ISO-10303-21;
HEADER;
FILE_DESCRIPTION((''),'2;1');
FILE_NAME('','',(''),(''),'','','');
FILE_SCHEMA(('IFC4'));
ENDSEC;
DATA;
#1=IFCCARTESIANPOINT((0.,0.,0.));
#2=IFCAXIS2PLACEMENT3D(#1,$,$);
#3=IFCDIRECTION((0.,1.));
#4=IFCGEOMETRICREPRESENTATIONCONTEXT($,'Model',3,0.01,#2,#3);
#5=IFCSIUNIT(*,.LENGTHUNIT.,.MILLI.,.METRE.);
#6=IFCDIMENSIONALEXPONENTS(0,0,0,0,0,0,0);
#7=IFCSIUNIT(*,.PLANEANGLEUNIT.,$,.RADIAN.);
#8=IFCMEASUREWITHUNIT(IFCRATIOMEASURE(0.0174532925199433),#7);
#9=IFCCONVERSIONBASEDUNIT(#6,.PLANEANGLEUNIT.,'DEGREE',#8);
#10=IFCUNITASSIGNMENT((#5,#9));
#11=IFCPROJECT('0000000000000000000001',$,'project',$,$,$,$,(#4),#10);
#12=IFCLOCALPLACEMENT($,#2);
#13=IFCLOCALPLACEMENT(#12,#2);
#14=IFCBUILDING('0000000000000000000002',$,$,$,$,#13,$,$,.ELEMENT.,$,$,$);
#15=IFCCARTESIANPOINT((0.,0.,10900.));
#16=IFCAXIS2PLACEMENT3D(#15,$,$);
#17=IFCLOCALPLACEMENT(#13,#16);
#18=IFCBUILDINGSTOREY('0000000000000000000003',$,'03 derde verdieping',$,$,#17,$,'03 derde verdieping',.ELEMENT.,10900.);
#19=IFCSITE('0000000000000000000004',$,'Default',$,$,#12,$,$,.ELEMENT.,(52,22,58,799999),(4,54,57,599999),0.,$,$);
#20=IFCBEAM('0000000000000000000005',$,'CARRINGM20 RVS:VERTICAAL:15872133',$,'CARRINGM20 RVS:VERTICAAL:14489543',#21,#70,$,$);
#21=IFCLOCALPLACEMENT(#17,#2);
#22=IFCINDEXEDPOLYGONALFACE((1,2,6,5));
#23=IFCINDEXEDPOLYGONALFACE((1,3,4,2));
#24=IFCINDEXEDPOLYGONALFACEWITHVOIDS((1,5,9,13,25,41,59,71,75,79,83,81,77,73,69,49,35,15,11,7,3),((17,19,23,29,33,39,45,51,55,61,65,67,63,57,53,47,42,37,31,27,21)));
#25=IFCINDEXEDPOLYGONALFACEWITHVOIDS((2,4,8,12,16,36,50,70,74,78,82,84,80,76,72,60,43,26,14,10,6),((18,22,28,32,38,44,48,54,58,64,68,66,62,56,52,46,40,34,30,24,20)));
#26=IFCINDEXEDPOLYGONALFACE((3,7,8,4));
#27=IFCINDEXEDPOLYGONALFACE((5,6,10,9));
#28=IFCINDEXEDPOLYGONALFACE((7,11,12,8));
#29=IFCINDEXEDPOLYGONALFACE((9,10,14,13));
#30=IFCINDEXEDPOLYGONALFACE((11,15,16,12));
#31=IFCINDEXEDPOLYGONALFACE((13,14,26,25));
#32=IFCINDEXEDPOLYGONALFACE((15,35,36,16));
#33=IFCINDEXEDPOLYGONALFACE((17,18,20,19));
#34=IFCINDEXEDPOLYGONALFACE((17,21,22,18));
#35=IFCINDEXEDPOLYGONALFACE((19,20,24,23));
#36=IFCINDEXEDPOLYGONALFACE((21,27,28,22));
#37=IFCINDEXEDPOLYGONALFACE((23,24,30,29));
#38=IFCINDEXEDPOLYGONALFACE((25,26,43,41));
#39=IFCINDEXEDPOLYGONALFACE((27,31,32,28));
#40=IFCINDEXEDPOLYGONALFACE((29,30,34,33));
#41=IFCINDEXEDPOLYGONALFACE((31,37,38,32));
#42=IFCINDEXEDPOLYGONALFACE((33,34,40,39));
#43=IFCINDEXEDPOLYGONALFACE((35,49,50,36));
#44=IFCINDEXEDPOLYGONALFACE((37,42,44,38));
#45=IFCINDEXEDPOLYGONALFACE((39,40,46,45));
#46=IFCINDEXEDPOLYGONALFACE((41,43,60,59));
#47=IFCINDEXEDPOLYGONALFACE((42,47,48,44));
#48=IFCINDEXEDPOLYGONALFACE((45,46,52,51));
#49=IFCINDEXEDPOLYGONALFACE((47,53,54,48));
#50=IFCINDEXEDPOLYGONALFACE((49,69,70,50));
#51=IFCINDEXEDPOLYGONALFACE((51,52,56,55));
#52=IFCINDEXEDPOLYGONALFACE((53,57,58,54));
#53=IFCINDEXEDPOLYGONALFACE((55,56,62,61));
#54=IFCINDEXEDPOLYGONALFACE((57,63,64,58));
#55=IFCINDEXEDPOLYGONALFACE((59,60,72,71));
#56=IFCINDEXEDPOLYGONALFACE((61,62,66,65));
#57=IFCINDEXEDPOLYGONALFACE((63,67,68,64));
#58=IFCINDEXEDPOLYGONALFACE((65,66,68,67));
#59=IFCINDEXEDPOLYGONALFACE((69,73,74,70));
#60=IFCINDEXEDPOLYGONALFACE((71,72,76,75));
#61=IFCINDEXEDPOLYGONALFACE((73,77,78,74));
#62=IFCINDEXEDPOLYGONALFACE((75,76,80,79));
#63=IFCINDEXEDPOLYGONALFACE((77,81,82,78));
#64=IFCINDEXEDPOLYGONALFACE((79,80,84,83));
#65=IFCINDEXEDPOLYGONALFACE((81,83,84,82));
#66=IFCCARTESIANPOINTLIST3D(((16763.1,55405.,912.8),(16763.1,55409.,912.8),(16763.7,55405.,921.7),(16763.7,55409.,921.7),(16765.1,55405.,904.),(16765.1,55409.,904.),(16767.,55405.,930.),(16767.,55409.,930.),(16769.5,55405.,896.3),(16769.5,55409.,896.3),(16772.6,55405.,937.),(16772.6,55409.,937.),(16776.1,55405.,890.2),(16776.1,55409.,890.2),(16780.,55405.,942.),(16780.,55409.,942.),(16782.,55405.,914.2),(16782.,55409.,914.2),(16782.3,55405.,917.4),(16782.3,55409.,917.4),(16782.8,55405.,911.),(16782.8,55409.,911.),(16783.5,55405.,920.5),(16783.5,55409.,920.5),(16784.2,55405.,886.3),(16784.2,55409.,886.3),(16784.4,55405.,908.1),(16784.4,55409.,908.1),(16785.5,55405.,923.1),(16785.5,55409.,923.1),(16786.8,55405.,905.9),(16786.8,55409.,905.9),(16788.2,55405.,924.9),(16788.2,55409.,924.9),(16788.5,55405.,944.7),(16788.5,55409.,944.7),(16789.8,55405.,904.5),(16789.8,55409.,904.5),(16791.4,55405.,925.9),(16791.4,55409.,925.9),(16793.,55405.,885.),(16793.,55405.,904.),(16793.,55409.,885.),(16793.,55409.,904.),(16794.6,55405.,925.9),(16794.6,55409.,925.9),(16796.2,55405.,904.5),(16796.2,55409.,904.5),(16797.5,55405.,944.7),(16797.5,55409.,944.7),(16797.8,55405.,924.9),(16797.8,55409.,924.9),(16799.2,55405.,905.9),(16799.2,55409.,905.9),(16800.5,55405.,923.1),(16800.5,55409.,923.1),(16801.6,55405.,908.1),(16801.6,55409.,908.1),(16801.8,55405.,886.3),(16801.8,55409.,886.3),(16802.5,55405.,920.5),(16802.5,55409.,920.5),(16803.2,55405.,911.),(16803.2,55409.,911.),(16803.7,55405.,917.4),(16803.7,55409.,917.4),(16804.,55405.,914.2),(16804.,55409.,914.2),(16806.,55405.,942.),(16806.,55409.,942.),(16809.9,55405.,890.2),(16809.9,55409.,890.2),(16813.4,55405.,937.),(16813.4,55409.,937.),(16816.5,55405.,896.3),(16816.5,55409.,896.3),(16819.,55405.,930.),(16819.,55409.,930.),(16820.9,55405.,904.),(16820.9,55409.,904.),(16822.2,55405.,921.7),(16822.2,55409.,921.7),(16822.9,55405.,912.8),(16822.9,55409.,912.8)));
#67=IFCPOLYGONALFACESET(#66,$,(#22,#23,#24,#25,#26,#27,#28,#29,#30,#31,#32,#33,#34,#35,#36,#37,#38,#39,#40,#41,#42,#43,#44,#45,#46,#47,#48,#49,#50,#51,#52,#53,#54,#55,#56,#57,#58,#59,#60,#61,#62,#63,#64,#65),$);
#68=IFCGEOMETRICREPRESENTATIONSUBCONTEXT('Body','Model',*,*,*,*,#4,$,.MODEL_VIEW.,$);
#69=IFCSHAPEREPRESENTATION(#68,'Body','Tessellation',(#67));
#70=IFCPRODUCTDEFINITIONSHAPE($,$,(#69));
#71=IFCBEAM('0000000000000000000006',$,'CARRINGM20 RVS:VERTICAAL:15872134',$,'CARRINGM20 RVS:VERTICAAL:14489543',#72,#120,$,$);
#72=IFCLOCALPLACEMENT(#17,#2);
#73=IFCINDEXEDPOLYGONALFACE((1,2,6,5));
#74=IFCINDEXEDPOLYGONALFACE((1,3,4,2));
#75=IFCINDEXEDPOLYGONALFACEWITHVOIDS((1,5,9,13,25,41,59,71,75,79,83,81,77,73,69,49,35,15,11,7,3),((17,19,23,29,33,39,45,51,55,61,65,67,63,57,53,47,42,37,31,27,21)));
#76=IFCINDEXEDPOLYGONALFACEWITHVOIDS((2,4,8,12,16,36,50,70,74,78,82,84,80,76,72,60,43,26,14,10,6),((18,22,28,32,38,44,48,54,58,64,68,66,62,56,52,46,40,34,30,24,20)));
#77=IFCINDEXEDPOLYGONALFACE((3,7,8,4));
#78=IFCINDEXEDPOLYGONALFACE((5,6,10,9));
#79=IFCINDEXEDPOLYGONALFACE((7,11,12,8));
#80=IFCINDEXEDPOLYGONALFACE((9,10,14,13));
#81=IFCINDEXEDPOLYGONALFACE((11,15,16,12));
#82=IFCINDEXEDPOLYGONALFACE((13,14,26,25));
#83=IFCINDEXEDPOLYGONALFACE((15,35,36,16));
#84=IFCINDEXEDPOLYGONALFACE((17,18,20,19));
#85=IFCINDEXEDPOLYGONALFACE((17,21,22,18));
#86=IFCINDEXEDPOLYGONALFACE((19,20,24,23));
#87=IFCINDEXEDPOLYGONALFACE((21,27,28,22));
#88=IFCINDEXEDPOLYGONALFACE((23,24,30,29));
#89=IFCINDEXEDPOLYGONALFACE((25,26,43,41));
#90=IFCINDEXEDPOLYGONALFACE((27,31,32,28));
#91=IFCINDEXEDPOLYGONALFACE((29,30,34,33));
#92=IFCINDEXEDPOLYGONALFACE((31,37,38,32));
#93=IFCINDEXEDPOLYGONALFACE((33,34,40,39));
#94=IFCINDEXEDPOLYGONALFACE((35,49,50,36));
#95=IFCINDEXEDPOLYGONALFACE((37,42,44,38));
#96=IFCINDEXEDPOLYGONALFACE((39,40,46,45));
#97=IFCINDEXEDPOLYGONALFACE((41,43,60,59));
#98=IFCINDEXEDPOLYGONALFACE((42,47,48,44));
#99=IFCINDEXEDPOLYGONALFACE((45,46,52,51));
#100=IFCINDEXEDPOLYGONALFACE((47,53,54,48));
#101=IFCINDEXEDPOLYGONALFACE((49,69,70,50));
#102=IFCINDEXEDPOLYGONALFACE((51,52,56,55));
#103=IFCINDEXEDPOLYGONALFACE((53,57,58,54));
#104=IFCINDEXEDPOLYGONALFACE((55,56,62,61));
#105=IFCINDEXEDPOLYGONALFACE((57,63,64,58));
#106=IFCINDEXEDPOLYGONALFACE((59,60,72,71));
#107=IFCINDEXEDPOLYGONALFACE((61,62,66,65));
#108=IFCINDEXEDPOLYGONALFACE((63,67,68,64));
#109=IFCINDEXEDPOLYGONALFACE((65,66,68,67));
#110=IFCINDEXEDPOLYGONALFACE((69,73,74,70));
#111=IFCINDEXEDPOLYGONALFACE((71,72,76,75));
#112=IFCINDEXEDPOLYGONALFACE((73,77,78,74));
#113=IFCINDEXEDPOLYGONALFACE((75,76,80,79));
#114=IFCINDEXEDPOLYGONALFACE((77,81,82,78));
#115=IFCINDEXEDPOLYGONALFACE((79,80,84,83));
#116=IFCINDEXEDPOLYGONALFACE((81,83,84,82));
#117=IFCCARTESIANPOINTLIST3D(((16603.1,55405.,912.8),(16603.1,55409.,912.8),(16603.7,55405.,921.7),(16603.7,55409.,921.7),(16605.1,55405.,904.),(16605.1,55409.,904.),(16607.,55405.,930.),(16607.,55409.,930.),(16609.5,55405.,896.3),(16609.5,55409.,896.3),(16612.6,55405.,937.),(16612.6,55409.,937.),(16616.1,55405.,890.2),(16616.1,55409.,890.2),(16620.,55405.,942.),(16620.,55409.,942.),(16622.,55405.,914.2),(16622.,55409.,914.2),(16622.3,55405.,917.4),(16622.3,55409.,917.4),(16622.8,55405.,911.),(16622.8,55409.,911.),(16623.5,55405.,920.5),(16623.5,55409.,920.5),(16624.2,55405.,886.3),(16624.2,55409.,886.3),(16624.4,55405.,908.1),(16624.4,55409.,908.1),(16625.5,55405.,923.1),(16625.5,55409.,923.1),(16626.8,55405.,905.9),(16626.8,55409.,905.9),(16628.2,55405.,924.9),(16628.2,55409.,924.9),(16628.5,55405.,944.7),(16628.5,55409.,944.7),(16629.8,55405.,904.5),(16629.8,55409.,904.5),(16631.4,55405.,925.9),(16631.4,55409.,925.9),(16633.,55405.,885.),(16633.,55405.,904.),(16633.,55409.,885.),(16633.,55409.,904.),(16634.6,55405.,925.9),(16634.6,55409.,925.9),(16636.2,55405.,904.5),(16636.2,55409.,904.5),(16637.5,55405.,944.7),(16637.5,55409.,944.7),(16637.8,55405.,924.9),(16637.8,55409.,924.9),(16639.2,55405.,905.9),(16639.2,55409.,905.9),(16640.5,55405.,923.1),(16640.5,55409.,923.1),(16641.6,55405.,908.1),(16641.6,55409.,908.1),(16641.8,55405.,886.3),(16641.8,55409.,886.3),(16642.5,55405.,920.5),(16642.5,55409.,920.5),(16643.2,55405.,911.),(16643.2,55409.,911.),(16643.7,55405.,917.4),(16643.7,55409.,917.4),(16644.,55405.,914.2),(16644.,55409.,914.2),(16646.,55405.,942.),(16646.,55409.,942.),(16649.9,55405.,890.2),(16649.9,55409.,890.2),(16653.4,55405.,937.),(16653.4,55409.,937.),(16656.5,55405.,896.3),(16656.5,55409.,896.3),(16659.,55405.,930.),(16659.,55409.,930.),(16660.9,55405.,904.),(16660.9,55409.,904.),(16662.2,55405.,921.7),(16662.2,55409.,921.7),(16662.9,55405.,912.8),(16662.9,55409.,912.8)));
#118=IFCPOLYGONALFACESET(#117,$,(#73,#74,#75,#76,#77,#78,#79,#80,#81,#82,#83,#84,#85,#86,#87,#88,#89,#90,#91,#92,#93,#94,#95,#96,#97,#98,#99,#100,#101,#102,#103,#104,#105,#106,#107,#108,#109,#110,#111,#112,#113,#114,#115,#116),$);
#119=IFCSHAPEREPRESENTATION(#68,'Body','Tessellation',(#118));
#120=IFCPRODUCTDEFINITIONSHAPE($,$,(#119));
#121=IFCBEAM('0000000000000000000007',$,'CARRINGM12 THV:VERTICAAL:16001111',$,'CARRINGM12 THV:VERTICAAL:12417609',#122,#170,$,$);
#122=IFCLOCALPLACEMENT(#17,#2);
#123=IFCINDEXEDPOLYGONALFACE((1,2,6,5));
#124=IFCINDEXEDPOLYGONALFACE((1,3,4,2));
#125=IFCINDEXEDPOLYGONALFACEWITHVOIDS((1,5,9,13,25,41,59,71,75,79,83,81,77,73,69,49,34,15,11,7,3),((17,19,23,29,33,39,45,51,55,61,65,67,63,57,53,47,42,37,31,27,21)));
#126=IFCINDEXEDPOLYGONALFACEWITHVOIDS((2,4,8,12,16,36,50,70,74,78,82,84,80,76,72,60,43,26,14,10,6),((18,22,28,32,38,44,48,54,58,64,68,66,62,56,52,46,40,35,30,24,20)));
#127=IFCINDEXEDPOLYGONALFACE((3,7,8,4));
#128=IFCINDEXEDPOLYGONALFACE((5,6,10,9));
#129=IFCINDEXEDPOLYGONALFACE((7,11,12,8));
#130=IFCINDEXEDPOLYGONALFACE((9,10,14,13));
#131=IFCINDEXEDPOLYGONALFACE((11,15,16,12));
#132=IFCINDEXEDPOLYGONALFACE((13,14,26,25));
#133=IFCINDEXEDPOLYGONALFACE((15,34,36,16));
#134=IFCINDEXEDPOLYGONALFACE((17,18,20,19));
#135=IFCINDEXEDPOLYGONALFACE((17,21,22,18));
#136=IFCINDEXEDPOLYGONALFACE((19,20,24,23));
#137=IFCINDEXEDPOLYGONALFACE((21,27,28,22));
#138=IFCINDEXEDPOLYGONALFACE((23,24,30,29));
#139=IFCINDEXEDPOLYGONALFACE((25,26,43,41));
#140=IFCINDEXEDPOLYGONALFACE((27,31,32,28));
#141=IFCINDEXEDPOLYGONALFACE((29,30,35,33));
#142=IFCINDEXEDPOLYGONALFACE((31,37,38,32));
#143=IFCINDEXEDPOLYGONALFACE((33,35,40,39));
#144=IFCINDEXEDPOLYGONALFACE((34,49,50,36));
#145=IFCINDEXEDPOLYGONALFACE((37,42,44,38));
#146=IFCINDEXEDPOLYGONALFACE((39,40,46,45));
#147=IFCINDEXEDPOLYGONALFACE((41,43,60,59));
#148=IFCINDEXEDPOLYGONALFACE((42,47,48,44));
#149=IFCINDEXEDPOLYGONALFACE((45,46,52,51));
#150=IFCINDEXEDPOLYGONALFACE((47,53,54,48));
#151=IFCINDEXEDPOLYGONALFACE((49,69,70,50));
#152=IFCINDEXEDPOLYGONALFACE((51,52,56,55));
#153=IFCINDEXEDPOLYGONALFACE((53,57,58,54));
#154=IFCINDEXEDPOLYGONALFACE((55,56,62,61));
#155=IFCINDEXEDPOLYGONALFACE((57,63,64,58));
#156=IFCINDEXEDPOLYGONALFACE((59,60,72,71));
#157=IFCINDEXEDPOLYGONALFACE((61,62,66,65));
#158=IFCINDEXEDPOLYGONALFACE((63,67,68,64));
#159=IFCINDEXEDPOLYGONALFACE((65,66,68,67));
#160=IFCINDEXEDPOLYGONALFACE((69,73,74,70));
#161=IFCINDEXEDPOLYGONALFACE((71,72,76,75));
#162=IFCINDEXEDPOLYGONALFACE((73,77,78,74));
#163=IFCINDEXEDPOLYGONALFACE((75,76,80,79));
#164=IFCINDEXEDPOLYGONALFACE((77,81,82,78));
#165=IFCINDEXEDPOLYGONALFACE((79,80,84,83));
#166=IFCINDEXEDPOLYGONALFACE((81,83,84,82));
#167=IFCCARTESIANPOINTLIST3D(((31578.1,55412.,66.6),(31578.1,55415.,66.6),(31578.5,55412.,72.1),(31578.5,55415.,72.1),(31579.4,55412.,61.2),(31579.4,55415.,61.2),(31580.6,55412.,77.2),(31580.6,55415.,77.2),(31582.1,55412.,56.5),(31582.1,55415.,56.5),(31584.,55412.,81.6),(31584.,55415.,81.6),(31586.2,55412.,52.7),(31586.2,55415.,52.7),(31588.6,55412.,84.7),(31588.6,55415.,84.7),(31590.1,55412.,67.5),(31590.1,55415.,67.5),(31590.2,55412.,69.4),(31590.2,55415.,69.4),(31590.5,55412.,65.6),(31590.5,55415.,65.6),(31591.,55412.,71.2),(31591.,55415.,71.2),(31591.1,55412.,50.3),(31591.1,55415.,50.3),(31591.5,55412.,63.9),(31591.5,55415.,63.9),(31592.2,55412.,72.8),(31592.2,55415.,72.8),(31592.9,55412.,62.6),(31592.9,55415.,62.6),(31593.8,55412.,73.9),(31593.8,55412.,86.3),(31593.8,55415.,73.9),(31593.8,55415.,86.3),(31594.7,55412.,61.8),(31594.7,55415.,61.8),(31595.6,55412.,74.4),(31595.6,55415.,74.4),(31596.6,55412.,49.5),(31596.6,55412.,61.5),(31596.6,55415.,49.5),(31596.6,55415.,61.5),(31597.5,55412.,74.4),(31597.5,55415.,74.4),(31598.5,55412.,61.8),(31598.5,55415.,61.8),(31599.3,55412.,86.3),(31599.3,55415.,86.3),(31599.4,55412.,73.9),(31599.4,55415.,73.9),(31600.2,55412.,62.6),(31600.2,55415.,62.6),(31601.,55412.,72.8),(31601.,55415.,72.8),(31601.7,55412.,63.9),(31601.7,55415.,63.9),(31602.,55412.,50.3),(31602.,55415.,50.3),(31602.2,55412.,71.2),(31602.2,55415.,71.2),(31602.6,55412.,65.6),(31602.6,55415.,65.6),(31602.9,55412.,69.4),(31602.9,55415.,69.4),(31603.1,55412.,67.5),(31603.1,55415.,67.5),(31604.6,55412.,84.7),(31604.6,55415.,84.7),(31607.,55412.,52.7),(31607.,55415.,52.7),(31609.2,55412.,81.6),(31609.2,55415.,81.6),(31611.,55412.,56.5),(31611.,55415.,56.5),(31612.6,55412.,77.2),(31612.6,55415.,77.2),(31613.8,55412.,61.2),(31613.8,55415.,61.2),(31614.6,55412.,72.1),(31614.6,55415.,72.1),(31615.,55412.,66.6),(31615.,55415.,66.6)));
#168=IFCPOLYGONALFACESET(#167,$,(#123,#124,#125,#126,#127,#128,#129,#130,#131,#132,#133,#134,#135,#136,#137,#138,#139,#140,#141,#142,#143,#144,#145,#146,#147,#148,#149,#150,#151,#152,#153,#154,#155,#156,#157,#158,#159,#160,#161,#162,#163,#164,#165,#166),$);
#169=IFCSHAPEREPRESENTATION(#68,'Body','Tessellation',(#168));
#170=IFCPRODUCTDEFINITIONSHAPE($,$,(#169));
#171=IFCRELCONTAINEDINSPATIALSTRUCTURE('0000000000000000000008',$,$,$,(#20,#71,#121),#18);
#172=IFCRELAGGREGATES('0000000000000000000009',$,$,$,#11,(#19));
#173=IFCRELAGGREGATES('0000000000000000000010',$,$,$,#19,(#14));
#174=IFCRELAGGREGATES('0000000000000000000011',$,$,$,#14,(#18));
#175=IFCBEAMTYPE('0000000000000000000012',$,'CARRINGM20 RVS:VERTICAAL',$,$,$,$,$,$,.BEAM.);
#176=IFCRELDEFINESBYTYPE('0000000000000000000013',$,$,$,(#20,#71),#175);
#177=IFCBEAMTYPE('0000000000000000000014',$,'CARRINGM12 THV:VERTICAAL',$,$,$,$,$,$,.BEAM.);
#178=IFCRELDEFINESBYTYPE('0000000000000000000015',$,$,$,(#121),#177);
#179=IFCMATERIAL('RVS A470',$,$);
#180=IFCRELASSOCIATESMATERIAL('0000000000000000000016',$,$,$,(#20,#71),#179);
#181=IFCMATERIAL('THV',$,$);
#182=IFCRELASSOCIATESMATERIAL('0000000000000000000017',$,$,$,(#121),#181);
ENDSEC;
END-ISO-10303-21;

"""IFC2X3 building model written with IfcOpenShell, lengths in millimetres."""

from ifc_helpers import new_model, entity, si_unit, converted_unit, direction, frame, origin, origin_2d_with_axis, place, context, subcontext, project, spatial, hollow_circle, extrude, material, type_object, element, save


model = new_model("IFC2X3")

# Units and contexts
model_context = context("Model", 3, precision=0.01, world=origin(), true_north=direction((0.0, 1.0)))
body_context = subcontext(model_context, "Body", "Model", "MODEL_VIEW")
ifc_project = project(units=[si_unit("LENGTHUNIT", "METRE", prefix="MILLI"), converted_unit("PLANEANGLEUNIT", "DEGREE", entity("IfcRatioMeasure", 0.0174532925199433), si_unit("PLANEANGLEUNIT", "RADIAN"), dimensions=[0, 0, 0, 0, 0, 0, 0])], contexts=[model_context])

# Site, building, storey
site_placement = place(None, origin())
site = spatial("IfcSite", under=ifc_project, at=site_placement, Name="Default", CompositionType="ELEMENT", RefLatitude=(52, 22, 58, 799999), RefLongitude=(4, 54, 57, 599999), RefElevation=0.0)
building_placement = place(site_placement, origin())
building = spatial("IfcBuilding", under=site, at=building_placement, CompositionType="ELEMENT")
storey_placement = place(building_placement, frame((0.0, 0.0, 10900.0)))
storey = spatial("IfcBuildingStorey", under=building, at=storey_placement, Name="03 derde verdieping", LongName="03 derde verdieping", CompositionType="ELEMENT", Elevation=10900.0)

# Beams
ifc_material_1 = material(Name="RVS A470")
beam_type_1 = type_object("IfcBeamType", Name="CARRINGM20 RVS:VERTICAAL", PredefinedType="BEAM")
beam_1_placement = place(storey_placement, origin())
element("IfcBeam", 1, at=beam_1_placement, inside=storey, type_object=beam_type_1, material=ifc_material_1, Name="CARRINGM20 RVS:VERTICAAL:15872133", ObjectType="CARRINGM20 RVS:VERTICAAL:14489543", context=body_context, shape_type="SweptSolid", body=[
    extrude(hollow_circle(Radius=30.0, WallThickness=19.0, at=origin_2d_with_axis()), frame((16793.0, 55405.0, 915.0), z_axis=(0.0, 1.0, 0.0), x_axis=(0.0, 0.0, -1.0)), (0.0, 0.0, 1.0), 4.0),
])
beam_2_placement = place(storey_placement, origin())
element("IfcBeam", 2, at=beam_2_placement, inside=storey, type_object=beam_type_1, material=ifc_material_1, Name="CARRINGM20 RVS:VERTICAAL:15872134", ObjectType="CARRINGM20 RVS:VERTICAAL:14489543", context=body_context, shape_type="SweptSolid", body=[
    extrude(hollow_circle(Radius=30.0, WallThickness=19.0, at=origin_2d_with_axis()), frame((16633.0, 55405.0, 915.0), z_axis=(0.0, 1.0, 0.0), x_axis=(0.0, 0.0, -1.0)), (0.0, 0.0, 1.0), 4.0),
])
ifc_material_2 = material(Name="THV")
beam_type_2 = type_object("IfcBeamType", Name="CARRINGM12 THV:VERTICAAL", PredefinedType="BEAM")
beam_3_placement = place(storey_placement, origin())
element("IfcBeam", 3, at=beam_3_placement, inside=storey, type_object=beam_type_2, material=ifc_material_2, Name="CARRINGM12 THV:VERTICAAL:16001111", ObjectType="CARRINGM12 THV:VERTICAAL:12417609", context=body_context, shape_type="SweptSolid", body=[
    extrude(hollow_circle(Radius=18.5, WallThickness=12.0, at=origin_2d_with_axis()), frame((31596.6, 55412.0, 68.0), z_axis=(0.0, 1.0, 0.0), x_axis=(0.0, 0.0, -1.0)), (0.0, 0.0, 1.0), 3.0),
])

save(model, "model.ifc")
